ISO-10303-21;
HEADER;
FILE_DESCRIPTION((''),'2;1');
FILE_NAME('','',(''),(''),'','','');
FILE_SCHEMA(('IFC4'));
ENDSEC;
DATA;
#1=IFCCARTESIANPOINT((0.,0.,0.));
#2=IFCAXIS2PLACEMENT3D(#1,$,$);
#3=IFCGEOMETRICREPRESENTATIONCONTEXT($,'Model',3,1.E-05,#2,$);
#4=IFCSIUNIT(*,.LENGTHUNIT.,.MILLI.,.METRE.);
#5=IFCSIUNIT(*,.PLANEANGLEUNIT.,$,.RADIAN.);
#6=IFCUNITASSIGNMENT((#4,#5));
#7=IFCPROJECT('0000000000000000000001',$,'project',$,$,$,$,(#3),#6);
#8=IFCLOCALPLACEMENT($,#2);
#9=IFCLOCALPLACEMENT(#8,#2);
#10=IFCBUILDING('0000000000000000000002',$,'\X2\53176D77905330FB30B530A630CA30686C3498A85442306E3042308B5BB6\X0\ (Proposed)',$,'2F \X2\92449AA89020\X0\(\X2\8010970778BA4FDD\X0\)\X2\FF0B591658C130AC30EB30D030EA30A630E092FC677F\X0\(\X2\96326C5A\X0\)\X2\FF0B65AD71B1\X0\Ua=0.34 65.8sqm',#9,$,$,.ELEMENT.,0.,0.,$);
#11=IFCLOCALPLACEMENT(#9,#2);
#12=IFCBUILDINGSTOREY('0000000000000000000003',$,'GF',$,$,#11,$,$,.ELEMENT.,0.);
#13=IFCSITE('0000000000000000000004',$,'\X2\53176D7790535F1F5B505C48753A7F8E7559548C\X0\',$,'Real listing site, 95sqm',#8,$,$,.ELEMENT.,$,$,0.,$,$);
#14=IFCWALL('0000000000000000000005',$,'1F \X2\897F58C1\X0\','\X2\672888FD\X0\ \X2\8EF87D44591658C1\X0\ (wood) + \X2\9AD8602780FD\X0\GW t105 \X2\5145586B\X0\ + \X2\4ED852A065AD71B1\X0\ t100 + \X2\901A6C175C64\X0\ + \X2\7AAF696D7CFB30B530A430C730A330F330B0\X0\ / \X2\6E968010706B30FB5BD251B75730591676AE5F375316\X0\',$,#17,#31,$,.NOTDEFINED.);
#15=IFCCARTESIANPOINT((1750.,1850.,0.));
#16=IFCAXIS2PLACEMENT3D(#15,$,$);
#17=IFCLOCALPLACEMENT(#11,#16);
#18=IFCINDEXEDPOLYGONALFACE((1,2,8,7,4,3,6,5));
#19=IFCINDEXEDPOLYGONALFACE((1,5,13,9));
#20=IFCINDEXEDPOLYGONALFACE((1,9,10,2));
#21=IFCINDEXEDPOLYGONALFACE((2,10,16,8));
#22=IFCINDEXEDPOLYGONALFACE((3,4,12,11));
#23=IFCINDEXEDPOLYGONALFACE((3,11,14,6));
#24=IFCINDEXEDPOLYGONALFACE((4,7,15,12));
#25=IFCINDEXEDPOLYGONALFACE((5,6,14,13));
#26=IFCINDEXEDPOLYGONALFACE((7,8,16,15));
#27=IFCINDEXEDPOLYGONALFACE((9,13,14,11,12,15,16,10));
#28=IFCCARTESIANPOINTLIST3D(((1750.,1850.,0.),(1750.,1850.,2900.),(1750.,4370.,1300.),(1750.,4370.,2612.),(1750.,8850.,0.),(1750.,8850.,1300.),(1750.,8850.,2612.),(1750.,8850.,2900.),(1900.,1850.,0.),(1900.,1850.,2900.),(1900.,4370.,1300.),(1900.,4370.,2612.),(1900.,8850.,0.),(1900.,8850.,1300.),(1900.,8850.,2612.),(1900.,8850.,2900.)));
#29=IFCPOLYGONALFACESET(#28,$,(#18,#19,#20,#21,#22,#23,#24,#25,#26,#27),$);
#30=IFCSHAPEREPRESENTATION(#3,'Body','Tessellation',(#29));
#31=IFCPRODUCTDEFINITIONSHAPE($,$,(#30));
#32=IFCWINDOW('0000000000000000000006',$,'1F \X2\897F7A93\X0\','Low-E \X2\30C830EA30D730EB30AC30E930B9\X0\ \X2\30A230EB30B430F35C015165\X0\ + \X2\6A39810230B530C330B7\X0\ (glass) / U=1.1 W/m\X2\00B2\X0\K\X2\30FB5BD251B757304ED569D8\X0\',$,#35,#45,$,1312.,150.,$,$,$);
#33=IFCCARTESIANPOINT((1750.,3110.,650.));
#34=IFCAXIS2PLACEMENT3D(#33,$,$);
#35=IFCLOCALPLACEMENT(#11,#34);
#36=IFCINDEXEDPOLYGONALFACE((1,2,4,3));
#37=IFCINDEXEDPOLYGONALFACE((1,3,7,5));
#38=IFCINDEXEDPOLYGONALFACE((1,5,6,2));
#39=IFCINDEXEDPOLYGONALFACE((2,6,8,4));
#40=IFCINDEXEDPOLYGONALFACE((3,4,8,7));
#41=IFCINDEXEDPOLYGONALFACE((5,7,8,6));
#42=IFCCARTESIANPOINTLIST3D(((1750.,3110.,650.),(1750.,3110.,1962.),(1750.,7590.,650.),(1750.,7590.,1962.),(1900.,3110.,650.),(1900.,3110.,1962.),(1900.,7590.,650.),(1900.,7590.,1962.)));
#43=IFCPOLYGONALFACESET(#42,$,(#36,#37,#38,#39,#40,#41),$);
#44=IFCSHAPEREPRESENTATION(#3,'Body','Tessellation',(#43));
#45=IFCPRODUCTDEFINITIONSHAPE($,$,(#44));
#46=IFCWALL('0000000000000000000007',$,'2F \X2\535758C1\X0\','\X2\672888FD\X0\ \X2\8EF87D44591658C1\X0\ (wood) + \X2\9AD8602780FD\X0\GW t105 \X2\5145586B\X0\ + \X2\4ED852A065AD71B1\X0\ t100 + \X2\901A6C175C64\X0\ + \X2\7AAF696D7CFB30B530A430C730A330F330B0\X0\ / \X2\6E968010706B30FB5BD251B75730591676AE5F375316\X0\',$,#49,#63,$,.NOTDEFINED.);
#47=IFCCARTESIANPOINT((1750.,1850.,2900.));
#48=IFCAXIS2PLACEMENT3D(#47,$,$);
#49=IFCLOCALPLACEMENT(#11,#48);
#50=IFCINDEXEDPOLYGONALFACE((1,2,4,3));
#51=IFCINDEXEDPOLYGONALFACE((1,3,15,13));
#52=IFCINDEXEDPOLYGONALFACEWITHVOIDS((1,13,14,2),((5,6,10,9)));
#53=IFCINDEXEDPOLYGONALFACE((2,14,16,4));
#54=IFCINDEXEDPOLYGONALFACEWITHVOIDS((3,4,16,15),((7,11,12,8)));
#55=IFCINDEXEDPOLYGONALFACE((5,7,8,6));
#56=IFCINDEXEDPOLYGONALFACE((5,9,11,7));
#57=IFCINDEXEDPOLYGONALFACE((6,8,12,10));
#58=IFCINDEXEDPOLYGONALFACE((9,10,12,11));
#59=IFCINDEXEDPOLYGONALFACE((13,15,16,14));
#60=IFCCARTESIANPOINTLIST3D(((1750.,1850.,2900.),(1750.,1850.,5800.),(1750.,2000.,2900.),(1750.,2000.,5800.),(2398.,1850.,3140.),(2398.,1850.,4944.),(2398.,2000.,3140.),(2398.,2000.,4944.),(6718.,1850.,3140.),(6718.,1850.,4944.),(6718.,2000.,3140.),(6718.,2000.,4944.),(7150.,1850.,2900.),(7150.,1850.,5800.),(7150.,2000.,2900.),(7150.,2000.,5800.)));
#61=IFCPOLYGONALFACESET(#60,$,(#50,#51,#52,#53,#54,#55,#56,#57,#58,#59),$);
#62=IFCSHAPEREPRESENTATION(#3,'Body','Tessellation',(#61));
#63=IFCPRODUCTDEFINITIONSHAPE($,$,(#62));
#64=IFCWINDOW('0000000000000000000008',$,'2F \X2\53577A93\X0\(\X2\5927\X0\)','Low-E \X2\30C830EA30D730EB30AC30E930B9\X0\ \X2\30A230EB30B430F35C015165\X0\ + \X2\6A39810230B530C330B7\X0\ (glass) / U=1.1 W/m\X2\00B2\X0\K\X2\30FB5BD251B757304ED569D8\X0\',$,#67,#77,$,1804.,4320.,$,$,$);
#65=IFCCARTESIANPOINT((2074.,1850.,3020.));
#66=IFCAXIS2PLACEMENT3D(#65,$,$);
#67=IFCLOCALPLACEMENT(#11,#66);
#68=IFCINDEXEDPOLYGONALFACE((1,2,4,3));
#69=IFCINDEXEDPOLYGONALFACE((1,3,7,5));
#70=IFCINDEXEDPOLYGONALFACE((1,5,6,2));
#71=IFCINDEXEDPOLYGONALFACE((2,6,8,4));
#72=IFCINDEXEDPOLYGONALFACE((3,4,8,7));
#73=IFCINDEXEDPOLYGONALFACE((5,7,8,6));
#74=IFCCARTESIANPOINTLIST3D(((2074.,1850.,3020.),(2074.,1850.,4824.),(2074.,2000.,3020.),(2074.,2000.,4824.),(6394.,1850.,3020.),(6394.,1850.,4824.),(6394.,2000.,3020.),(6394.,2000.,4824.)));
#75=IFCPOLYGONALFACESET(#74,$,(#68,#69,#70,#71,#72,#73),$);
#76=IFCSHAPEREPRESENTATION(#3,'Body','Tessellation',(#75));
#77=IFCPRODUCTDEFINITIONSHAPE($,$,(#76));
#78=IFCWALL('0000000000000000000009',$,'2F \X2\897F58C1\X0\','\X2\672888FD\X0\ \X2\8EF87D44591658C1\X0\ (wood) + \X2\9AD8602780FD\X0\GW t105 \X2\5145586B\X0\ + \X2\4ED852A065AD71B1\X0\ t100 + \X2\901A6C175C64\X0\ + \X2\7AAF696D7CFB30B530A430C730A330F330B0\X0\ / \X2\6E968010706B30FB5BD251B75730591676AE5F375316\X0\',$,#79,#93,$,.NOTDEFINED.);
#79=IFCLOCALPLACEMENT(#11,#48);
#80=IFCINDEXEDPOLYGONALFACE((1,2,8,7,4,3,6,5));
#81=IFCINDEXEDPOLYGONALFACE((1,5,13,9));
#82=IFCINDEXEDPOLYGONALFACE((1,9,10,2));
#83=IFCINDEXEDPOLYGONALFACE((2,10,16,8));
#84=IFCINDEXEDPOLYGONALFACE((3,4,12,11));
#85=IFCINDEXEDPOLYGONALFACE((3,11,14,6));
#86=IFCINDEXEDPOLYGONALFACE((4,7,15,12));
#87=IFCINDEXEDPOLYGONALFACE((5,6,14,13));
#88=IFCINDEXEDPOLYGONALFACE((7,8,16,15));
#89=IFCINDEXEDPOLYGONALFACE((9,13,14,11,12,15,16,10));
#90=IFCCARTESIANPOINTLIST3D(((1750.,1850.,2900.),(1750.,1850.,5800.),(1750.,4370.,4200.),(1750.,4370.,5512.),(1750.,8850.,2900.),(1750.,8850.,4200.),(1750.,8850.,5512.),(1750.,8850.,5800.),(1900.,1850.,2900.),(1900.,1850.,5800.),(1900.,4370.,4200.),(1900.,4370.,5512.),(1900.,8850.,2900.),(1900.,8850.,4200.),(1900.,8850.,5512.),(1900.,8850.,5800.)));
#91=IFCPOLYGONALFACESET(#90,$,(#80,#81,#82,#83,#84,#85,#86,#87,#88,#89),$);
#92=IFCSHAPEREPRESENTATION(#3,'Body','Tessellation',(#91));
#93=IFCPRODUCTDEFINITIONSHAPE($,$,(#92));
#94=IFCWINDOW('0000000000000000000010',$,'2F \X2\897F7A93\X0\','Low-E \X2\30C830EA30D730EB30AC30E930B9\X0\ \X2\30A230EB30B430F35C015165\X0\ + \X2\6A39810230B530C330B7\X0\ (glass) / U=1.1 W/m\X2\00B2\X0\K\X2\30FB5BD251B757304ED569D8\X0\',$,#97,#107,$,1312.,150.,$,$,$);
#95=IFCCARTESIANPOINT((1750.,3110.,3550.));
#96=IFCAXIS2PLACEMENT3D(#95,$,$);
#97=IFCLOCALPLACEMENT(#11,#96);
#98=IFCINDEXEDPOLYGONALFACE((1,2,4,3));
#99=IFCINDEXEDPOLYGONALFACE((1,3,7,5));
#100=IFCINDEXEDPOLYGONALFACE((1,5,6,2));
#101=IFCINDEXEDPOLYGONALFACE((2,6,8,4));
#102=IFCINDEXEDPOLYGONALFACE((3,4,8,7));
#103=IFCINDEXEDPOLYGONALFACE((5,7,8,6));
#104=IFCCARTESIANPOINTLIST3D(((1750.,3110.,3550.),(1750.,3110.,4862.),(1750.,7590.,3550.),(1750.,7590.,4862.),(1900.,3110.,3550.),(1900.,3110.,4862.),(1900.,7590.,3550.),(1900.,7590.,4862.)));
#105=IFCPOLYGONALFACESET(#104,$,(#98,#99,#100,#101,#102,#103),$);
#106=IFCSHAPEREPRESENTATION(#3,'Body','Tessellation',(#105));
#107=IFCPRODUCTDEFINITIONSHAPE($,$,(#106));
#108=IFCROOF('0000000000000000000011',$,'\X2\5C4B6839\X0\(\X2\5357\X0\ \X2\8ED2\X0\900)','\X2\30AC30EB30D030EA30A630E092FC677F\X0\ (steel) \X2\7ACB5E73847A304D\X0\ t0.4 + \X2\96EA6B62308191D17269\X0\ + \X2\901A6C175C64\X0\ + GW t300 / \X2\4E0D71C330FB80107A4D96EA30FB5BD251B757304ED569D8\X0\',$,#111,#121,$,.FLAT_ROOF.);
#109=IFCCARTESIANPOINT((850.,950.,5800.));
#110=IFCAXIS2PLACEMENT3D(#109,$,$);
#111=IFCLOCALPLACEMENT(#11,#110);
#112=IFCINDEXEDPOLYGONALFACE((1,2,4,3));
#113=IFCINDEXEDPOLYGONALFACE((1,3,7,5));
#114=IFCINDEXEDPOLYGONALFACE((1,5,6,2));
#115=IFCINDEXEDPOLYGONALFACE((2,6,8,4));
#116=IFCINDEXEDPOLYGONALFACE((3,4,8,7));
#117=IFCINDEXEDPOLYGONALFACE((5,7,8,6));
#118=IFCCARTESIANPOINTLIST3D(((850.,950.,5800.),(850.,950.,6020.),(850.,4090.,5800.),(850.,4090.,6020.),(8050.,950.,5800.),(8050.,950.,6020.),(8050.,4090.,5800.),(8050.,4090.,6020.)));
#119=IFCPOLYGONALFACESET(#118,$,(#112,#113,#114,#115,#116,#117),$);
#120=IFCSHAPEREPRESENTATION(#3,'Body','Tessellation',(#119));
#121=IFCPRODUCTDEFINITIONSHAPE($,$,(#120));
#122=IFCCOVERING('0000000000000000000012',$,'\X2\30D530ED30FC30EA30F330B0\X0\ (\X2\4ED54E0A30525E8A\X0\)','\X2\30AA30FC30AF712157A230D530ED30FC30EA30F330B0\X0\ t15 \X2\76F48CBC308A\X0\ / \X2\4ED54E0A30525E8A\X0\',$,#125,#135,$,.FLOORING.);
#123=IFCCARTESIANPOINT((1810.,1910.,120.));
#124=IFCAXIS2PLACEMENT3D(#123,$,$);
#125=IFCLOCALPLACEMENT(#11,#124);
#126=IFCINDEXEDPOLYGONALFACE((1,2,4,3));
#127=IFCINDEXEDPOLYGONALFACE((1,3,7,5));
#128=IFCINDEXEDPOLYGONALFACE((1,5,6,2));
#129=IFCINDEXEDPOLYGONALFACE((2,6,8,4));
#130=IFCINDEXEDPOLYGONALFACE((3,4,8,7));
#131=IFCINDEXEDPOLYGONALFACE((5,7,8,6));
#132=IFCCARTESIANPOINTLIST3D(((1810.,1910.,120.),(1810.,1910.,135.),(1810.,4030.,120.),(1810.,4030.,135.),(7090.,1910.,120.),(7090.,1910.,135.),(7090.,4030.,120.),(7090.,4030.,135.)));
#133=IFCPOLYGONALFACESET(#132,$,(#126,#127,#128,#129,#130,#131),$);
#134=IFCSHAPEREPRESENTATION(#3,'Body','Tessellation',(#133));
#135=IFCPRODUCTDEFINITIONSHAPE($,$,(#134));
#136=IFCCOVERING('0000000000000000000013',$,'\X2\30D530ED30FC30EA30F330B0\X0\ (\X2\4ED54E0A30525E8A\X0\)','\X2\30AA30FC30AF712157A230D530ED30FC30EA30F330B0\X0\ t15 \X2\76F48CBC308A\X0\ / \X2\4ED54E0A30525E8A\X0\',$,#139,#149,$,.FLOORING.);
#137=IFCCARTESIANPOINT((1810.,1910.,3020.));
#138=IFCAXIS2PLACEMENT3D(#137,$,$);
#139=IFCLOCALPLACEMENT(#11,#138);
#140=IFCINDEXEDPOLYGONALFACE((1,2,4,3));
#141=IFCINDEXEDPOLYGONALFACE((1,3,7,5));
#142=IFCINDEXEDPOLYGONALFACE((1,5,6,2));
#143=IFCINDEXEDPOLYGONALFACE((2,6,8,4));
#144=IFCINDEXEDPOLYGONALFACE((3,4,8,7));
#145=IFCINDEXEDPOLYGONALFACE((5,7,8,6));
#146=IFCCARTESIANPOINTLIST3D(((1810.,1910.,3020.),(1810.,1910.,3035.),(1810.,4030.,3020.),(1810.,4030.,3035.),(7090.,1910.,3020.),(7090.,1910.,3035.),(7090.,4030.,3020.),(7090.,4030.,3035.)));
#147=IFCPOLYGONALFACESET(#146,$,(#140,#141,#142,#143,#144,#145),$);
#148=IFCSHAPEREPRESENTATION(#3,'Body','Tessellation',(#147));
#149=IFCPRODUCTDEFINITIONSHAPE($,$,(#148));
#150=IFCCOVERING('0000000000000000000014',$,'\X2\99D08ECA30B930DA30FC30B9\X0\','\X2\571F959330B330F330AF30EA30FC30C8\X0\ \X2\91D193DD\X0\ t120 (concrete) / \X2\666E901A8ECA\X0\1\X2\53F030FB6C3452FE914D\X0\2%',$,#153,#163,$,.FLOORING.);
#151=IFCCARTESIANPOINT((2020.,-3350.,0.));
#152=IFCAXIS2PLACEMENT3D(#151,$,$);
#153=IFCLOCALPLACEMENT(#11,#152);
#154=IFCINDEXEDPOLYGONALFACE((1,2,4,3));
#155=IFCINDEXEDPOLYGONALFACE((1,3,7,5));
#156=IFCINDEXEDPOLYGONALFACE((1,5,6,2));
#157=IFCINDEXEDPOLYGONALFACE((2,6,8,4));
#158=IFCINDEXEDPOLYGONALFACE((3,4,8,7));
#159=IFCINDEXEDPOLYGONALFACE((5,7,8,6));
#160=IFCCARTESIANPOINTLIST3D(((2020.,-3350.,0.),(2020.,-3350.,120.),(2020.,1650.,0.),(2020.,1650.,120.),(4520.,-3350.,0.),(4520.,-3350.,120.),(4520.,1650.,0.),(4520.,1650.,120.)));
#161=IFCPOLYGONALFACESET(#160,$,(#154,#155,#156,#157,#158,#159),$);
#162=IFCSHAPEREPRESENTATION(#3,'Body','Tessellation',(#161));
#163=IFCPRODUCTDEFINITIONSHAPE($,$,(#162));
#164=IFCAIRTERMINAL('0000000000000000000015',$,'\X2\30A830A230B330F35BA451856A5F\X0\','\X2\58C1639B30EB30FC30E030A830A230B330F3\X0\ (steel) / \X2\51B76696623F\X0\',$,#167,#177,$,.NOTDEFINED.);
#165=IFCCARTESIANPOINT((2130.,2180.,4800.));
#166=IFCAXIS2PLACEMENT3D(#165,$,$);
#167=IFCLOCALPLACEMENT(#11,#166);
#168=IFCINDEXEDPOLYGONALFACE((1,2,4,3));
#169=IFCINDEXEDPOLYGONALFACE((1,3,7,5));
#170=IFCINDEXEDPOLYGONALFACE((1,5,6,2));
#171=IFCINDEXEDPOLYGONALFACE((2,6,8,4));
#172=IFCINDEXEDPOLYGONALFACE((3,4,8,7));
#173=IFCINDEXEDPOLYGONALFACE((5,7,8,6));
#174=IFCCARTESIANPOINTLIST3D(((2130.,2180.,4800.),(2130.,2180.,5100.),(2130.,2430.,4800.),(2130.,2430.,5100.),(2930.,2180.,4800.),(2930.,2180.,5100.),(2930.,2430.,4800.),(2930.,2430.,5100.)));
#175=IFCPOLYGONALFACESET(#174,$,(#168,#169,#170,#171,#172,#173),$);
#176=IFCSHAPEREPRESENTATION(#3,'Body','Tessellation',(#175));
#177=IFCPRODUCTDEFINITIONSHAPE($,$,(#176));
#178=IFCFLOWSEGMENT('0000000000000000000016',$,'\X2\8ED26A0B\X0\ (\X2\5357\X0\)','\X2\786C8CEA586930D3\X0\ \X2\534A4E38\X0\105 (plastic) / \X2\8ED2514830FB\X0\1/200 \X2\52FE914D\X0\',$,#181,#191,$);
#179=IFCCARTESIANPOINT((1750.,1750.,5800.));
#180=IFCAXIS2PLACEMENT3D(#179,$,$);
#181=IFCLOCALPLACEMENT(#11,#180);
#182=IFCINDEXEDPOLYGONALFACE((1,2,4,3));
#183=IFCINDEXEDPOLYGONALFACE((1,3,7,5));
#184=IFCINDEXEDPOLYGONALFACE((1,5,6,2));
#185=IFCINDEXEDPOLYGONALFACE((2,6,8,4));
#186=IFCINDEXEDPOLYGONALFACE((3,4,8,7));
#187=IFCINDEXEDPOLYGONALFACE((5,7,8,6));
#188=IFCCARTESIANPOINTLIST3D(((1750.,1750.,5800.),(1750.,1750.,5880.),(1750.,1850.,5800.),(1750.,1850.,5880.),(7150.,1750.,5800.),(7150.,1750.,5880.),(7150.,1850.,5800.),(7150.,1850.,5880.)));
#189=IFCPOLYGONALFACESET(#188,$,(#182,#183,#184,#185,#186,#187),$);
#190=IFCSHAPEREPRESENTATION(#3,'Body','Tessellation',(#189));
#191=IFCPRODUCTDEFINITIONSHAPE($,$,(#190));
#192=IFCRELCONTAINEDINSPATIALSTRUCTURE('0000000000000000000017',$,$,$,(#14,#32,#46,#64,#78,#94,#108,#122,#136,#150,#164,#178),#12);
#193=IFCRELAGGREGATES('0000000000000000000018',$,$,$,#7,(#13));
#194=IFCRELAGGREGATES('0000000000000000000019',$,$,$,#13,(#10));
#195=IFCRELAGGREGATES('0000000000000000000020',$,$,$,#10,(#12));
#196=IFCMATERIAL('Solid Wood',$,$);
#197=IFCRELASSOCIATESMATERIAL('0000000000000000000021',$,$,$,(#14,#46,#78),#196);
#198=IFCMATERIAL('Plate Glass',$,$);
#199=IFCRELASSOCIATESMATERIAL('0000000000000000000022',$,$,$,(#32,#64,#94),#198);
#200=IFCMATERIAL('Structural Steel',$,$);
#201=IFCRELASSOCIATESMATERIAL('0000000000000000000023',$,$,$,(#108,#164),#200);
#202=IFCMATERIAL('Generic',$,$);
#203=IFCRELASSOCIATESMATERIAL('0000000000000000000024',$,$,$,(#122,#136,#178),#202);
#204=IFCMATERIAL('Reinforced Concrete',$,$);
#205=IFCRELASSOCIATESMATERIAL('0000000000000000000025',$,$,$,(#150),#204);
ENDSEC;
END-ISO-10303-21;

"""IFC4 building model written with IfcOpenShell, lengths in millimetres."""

from ifc_helpers import new_model, si_unit, frame, frame_2d, origin, place, context, project, spatial, rectangle, extrude, material, element, fill, save


model = new_model("IFC4")

# Units and contexts
model_context = context("Model", 3, precision=1e-05, world=origin())
ifc_project = project(units=[si_unit("LENGTHUNIT", "METRE", prefix="MILLI"), si_unit("PLANEANGLEUNIT", "RADIAN")], contexts=[model_context])

# Site, building, storey
site_placement = place(None, origin())
site = spatial("IfcSite", under=ifc_project, at=site_placement, Name="北海道弟子屈町美留和", ObjectType="Real listing site, 95sqm", CompositionType="ELEMENT", RefElevation=0.0)
building_placement = place(site_placement, origin())
building = spatial("IfcBuilding", under=site, at=building_placement, Name="北海道・サウナと水風呂のある家 (Proposed)", ObjectType="2F 鉄骨造(耐震確保)＋外壁ガルバリウム鋼板(防汚)＋断熱Ua=0.34 65.8sqm", CompositionType="ELEMENT", ElevationOfRefHeight=0.0, ElevationOfTerrain=0.0)
storey_placement = place(building_placement, origin())
storey = spatial("IfcBuildingStorey", under=building, at=storey_placement, Name="GF", CompositionType="ELEMENT", Elevation=0.0)

# Shared definitions
ifc_material_1 = material(Name="Solid Wood")

# Shared definitions
ifc_material_2 = material(Name="Reinforced Concrete")

# Shared definitions
ifc_material_3 = material(Name="Plate Glass")

# Walls, openings, windows
wall_1_placement = place(storey_placement, frame((1750.0, 1850.0, 0.0)))
wall_1 = element("IfcWall", 1, at=wall_1_placement, inside=storey, material=ifc_material_1, Name="1F 西壁", Description="木製 軸組外壁 (wood) + 高性能GW t105 充填 + 付加断熱 t100 + 通気層 + 窯業系サイディング / 準耐火・寒冷地外皮強化", PredefinedType="NOTDEFINED", context=model_context, shape_type="SweptSolid", body=[
    extrude(rectangle(XDim=150.0, YDim=7000.0, at=frame_2d((75.0, 3500.0))), frame((1750.0, 1850.0, 0.0)), (0.0, 0.0, 1.0), 2900.0),
])
opening_1_placement = place(storey_placement, frame((1750.0, 3110.0, 650.0)))
opening_1 = element("IfcOpeningElement", 2, at=opening_1_placement, cuts=wall_1, PredefinedType="NOTDEFINED", context=model_context, shape_type="SweptSolid", body=[
    extrude(rectangle(XDim=150.0, YDim=4480.0, at=frame_2d((75.0, 2240.0))), frame((1750.0, 3110.0, 650.0)), (0.0, 0.0, 1.0), 1312.0),
])
window_1_placement = place(storey_placement, frame((1750.0, 3110.0, 650.0)))
window_1 = element("IfcWindow", 3, at=window_1_placement, inside=storey, material=ifc_material_3, Name="1F 西窓", Description="Low-E トリプルガラス アルゴン封入 + 樹脂サッシ (glass) / U=1.1 W/m²K・寒冷地仕様", OverallHeight=1312.0, OverallWidth=150.0, context=model_context, shape_type="SweptSolid", body=[
    extrude(rectangle(XDim=150.0, YDim=4480.0, at=frame_2d((75.0, 2240.0))), frame((1750.0, 3110.0, 650.0)), (0.0, 0.0, 1.0), 1312.0),
])
fill(opening_1, window_1)
wall_2_placement = place(storey_placement, frame((1750.0, 1850.0, 2900.0)))
wall_2 = element("IfcWall", 4, at=wall_2_placement, inside=storey, material=ifc_material_1, Name="2F 南壁", Description="木製 軸組外壁 (wood) + 高性能GW t105 充填 + 付加断熱 t100 + 通気層 + 窯業系サイディング / 準耐火・寒冷地外皮強化", PredefinedType="NOTDEFINED", context=model_context, shape_type="SweptSolid", body=[
    extrude(rectangle(XDim=5400.0, YDim=150.0, at=frame_2d((2700.0, 75.0))), frame((1750.0, 1850.0, 2900.0)), (0.0, 0.0, 1.0), 2900.0),
])
opening_2_placement = place(storey_placement, frame((2074.0, 1850.0, 3020.0)))
opening_2 = element("IfcOpeningElement", 5, at=opening_2_placement, cuts=wall_2, PredefinedType="NOTDEFINED", context=model_context, shape_type="SweptSolid", body=[
    extrude(rectangle(XDim=4320.0, YDim=150.0, at=frame_2d((2160.0, 75.0))), frame((2074.0, 1850.0, 3020.0)), (0.0, 0.0, 1.0), 1804.0),
])
window_2_placement = place(storey_placement, frame((2074.0, 1850.0, 3020.0)))
window_2 = element("IfcWindow", 6, at=window_2_placement, inside=storey, material=ifc_material_3, Name="2F 南窓(大)", Description="Low-E トリプルガラス アルゴン封入 + 樹脂サッシ (glass) / U=1.1 W/m²K・寒冷地仕様", OverallHeight=1804.0, OverallWidth=4320.0, context=model_context, shape_type="SweptSolid", body=[
    extrude(rectangle(XDim=4320.0, YDim=150.0, at=frame_2d((2160.0, 75.0))), frame((2074.0, 1850.0, 3020.0)), (0.0, 0.0, 1.0), 1804.0),
])
fill(opening_2, window_2)
wall_3_placement = place(storey_placement, frame((1750.0, 1850.0, 2900.0)))
wall_3 = element("IfcWall", 7, at=wall_3_placement, inside=storey, material=ifc_material_1, Name="2F 西壁", Description="木製 軸組外壁 (wood) + 高性能GW t105 充填 + 付加断熱 t100 + 通気層 + 窯業系サイディング / 準耐火・寒冷地外皮強化", PredefinedType="NOTDEFINED", context=model_context, shape_type="SweptSolid", body=[
    extrude(rectangle(XDim=150.0, YDim=7000.0, at=frame_2d((75.0, 3500.0))), frame((1750.0, 1850.0, 2900.0)), (0.0, 0.0, 1.0), 2900.0),
])
opening_3_placement = place(storey_placement, frame((1750.0, 3110.0, 3550.0)))
opening_3 = element("IfcOpeningElement", 8, at=opening_3_placement, cuts=wall_3, PredefinedType="NOTDEFINED", context=model_context, shape_type="SweptSolid", body=[
    extrude(rectangle(XDim=150.0, YDim=4480.0, at=frame_2d((75.0, 2240.0))), frame((1750.0, 3110.0, 3550.0)), (0.0, 0.0, 1.0), 1312.0),
])
window_3_placement = place(storey_placement, frame((1750.0, 3110.0, 3550.0)))
window_3 = element("IfcWindow", 9, at=window_3_placement, inside=storey, material=ifc_material_3, Name="2F 西窓", Description="Low-E トリプルガラス アルゴン封入 + 樹脂サッシ (glass) / U=1.1 W/m²K・寒冷地仕様", OverallHeight=1312.0, OverallWidth=150.0, context=model_context, shape_type="SweptSolid", body=[
    extrude(rectangle(XDim=150.0, YDim=4480.0, at=frame_2d((75.0, 2240.0))), frame((1750.0, 3110.0, 3550.0)), (0.0, 0.0, 1.0), 1312.0),
])
fill(opening_3, window_3)

# Roof
ifc_material_4 = material(Name="Structural Steel")
for number, where, name in (
    (10, (850.0, 950.0, 5800.0), "屋根(南 軒900)"),
):
    element("IfcRoof", number, at=place(storey_placement, frame(where)), inside=storey, material=ifc_material_4, Name=name, Description="ガルバリウム鋼板 (steel) 立平葺き t0.4 + 雪止め金物 + 通気層 + GW t300 / 不燃・耐積雪・寒冷地仕様", PredefinedType="FLAT_ROOF", context=model_context, shape_type="SweptSolid", body=[
        extrude(rectangle(XDim=7200.0, YDim=3140.0, at=frame_2d((3600.0, 1570.0))), frame((850.0, 950.0, 5800.0)), (0.0, 0.0, 1.0), 220.0),
    ])

# Coverings
ifc_material_5 = material(Name="Generic")
covering_1_placement = place(storey_placement, frame((1810.0, 1910.0, 120.0)))
element("IfcCovering", 11, at=covering_1_placement, inside=storey, material=ifc_material_5, Name="フローリング (仕上げ床)", Description="オーク無垢フローリング t15 直貼り / 仕上げ床", PredefinedType="FLOORING", context=model_context, shape_type="SweptSolid", body=[
    extrude(rectangle(XDim=5280.0, YDim=2120.0, at=frame_2d((2640.0, 1060.0))), frame((1810.0, 1910.0, 120.0)), (0.0, 0.0, 1.0), 15.0),
])
covering_2_placement = place(storey_placement, frame((1810.0, 1910.0, 3020.0)))
element("IfcCovering", 12, at=covering_2_placement, inside=storey, material=ifc_material_5, Name="フローリング (仕上げ床)", Description="オーク無垢フローリング t15 直貼り / 仕上げ床", PredefinedType="FLOORING", context=model_context, shape_type="SweptSolid", body=[
    extrude(rectangle(XDim=5280.0, YDim=2120.0, at=frame_2d((2640.0, 1060.0))), frame((1810.0, 1910.0, 3020.0)), (0.0, 0.0, 1.0), 15.0),
])
covering_3_placement = place(storey_placement, frame((2020.0, -3350.0, 0.0)))
element("IfcCovering", 13, at=covering_3_placement, inside=storey, material=ifc_material_2, Name="駐車スペース", Description="土間コンクリート 金鏝 t120 (concrete) / 普通車1台・水勾配2%", PredefinedType="FLOORING", context=model_context, shape_type="SweptSolid", body=[
    extrude(rectangle(XDim=2500.0, YDim=5000.0, at=frame_2d((1250.0, 2500.0))), frame((2020.0, -3350.0, 0.0)), (0.0, 0.0, 1.0), 120.0),
])

# Air terminal
air_terminal_placement = place(storey_placement, frame((2130.0, 2180.0, 4800.0)))
element("IfcAirTerminal", 14, at=air_terminal_placement, inside=storey, material=ifc_material_4, Name="エアコン室内機", Description="壁掛ルームエアコン (steel) / 冷暖房", PredefinedType="NOTDEFINED", context=model_context, shape_type="SweptSolid", body=[
    extrude(rectangle(XDim=800.0, YDim=250.0, at=frame_2d((400.0, 125.0))), frame((2130.0, 2180.0, 4800.0)), (0.0, 0.0, 1.0), 300.0),
])

# Flow segment
flow_segment_1_placement = place(storey_placement, frame((1750.0, 1750.0, 5800.0)))
element("IfcFlowSegment", 15, at=flow_segment_1_placement, inside=storey, material=ifc_material_5, Name="軒樋 (南)", Description="硬質塩ビ 半丸105 (plastic) / 軒先・1/200 勾配", context=model_context, shape_type="SweptSolid", body=[
    extrude(rectangle(XDim=5400.0, YDim=100.0, at=frame_2d((2700.0, 50.0))), frame((1750.0, 1750.0, 5800.0)), (0.0, 0.0, 1.0), 80.0),
])

save(model, "model.ifc")
